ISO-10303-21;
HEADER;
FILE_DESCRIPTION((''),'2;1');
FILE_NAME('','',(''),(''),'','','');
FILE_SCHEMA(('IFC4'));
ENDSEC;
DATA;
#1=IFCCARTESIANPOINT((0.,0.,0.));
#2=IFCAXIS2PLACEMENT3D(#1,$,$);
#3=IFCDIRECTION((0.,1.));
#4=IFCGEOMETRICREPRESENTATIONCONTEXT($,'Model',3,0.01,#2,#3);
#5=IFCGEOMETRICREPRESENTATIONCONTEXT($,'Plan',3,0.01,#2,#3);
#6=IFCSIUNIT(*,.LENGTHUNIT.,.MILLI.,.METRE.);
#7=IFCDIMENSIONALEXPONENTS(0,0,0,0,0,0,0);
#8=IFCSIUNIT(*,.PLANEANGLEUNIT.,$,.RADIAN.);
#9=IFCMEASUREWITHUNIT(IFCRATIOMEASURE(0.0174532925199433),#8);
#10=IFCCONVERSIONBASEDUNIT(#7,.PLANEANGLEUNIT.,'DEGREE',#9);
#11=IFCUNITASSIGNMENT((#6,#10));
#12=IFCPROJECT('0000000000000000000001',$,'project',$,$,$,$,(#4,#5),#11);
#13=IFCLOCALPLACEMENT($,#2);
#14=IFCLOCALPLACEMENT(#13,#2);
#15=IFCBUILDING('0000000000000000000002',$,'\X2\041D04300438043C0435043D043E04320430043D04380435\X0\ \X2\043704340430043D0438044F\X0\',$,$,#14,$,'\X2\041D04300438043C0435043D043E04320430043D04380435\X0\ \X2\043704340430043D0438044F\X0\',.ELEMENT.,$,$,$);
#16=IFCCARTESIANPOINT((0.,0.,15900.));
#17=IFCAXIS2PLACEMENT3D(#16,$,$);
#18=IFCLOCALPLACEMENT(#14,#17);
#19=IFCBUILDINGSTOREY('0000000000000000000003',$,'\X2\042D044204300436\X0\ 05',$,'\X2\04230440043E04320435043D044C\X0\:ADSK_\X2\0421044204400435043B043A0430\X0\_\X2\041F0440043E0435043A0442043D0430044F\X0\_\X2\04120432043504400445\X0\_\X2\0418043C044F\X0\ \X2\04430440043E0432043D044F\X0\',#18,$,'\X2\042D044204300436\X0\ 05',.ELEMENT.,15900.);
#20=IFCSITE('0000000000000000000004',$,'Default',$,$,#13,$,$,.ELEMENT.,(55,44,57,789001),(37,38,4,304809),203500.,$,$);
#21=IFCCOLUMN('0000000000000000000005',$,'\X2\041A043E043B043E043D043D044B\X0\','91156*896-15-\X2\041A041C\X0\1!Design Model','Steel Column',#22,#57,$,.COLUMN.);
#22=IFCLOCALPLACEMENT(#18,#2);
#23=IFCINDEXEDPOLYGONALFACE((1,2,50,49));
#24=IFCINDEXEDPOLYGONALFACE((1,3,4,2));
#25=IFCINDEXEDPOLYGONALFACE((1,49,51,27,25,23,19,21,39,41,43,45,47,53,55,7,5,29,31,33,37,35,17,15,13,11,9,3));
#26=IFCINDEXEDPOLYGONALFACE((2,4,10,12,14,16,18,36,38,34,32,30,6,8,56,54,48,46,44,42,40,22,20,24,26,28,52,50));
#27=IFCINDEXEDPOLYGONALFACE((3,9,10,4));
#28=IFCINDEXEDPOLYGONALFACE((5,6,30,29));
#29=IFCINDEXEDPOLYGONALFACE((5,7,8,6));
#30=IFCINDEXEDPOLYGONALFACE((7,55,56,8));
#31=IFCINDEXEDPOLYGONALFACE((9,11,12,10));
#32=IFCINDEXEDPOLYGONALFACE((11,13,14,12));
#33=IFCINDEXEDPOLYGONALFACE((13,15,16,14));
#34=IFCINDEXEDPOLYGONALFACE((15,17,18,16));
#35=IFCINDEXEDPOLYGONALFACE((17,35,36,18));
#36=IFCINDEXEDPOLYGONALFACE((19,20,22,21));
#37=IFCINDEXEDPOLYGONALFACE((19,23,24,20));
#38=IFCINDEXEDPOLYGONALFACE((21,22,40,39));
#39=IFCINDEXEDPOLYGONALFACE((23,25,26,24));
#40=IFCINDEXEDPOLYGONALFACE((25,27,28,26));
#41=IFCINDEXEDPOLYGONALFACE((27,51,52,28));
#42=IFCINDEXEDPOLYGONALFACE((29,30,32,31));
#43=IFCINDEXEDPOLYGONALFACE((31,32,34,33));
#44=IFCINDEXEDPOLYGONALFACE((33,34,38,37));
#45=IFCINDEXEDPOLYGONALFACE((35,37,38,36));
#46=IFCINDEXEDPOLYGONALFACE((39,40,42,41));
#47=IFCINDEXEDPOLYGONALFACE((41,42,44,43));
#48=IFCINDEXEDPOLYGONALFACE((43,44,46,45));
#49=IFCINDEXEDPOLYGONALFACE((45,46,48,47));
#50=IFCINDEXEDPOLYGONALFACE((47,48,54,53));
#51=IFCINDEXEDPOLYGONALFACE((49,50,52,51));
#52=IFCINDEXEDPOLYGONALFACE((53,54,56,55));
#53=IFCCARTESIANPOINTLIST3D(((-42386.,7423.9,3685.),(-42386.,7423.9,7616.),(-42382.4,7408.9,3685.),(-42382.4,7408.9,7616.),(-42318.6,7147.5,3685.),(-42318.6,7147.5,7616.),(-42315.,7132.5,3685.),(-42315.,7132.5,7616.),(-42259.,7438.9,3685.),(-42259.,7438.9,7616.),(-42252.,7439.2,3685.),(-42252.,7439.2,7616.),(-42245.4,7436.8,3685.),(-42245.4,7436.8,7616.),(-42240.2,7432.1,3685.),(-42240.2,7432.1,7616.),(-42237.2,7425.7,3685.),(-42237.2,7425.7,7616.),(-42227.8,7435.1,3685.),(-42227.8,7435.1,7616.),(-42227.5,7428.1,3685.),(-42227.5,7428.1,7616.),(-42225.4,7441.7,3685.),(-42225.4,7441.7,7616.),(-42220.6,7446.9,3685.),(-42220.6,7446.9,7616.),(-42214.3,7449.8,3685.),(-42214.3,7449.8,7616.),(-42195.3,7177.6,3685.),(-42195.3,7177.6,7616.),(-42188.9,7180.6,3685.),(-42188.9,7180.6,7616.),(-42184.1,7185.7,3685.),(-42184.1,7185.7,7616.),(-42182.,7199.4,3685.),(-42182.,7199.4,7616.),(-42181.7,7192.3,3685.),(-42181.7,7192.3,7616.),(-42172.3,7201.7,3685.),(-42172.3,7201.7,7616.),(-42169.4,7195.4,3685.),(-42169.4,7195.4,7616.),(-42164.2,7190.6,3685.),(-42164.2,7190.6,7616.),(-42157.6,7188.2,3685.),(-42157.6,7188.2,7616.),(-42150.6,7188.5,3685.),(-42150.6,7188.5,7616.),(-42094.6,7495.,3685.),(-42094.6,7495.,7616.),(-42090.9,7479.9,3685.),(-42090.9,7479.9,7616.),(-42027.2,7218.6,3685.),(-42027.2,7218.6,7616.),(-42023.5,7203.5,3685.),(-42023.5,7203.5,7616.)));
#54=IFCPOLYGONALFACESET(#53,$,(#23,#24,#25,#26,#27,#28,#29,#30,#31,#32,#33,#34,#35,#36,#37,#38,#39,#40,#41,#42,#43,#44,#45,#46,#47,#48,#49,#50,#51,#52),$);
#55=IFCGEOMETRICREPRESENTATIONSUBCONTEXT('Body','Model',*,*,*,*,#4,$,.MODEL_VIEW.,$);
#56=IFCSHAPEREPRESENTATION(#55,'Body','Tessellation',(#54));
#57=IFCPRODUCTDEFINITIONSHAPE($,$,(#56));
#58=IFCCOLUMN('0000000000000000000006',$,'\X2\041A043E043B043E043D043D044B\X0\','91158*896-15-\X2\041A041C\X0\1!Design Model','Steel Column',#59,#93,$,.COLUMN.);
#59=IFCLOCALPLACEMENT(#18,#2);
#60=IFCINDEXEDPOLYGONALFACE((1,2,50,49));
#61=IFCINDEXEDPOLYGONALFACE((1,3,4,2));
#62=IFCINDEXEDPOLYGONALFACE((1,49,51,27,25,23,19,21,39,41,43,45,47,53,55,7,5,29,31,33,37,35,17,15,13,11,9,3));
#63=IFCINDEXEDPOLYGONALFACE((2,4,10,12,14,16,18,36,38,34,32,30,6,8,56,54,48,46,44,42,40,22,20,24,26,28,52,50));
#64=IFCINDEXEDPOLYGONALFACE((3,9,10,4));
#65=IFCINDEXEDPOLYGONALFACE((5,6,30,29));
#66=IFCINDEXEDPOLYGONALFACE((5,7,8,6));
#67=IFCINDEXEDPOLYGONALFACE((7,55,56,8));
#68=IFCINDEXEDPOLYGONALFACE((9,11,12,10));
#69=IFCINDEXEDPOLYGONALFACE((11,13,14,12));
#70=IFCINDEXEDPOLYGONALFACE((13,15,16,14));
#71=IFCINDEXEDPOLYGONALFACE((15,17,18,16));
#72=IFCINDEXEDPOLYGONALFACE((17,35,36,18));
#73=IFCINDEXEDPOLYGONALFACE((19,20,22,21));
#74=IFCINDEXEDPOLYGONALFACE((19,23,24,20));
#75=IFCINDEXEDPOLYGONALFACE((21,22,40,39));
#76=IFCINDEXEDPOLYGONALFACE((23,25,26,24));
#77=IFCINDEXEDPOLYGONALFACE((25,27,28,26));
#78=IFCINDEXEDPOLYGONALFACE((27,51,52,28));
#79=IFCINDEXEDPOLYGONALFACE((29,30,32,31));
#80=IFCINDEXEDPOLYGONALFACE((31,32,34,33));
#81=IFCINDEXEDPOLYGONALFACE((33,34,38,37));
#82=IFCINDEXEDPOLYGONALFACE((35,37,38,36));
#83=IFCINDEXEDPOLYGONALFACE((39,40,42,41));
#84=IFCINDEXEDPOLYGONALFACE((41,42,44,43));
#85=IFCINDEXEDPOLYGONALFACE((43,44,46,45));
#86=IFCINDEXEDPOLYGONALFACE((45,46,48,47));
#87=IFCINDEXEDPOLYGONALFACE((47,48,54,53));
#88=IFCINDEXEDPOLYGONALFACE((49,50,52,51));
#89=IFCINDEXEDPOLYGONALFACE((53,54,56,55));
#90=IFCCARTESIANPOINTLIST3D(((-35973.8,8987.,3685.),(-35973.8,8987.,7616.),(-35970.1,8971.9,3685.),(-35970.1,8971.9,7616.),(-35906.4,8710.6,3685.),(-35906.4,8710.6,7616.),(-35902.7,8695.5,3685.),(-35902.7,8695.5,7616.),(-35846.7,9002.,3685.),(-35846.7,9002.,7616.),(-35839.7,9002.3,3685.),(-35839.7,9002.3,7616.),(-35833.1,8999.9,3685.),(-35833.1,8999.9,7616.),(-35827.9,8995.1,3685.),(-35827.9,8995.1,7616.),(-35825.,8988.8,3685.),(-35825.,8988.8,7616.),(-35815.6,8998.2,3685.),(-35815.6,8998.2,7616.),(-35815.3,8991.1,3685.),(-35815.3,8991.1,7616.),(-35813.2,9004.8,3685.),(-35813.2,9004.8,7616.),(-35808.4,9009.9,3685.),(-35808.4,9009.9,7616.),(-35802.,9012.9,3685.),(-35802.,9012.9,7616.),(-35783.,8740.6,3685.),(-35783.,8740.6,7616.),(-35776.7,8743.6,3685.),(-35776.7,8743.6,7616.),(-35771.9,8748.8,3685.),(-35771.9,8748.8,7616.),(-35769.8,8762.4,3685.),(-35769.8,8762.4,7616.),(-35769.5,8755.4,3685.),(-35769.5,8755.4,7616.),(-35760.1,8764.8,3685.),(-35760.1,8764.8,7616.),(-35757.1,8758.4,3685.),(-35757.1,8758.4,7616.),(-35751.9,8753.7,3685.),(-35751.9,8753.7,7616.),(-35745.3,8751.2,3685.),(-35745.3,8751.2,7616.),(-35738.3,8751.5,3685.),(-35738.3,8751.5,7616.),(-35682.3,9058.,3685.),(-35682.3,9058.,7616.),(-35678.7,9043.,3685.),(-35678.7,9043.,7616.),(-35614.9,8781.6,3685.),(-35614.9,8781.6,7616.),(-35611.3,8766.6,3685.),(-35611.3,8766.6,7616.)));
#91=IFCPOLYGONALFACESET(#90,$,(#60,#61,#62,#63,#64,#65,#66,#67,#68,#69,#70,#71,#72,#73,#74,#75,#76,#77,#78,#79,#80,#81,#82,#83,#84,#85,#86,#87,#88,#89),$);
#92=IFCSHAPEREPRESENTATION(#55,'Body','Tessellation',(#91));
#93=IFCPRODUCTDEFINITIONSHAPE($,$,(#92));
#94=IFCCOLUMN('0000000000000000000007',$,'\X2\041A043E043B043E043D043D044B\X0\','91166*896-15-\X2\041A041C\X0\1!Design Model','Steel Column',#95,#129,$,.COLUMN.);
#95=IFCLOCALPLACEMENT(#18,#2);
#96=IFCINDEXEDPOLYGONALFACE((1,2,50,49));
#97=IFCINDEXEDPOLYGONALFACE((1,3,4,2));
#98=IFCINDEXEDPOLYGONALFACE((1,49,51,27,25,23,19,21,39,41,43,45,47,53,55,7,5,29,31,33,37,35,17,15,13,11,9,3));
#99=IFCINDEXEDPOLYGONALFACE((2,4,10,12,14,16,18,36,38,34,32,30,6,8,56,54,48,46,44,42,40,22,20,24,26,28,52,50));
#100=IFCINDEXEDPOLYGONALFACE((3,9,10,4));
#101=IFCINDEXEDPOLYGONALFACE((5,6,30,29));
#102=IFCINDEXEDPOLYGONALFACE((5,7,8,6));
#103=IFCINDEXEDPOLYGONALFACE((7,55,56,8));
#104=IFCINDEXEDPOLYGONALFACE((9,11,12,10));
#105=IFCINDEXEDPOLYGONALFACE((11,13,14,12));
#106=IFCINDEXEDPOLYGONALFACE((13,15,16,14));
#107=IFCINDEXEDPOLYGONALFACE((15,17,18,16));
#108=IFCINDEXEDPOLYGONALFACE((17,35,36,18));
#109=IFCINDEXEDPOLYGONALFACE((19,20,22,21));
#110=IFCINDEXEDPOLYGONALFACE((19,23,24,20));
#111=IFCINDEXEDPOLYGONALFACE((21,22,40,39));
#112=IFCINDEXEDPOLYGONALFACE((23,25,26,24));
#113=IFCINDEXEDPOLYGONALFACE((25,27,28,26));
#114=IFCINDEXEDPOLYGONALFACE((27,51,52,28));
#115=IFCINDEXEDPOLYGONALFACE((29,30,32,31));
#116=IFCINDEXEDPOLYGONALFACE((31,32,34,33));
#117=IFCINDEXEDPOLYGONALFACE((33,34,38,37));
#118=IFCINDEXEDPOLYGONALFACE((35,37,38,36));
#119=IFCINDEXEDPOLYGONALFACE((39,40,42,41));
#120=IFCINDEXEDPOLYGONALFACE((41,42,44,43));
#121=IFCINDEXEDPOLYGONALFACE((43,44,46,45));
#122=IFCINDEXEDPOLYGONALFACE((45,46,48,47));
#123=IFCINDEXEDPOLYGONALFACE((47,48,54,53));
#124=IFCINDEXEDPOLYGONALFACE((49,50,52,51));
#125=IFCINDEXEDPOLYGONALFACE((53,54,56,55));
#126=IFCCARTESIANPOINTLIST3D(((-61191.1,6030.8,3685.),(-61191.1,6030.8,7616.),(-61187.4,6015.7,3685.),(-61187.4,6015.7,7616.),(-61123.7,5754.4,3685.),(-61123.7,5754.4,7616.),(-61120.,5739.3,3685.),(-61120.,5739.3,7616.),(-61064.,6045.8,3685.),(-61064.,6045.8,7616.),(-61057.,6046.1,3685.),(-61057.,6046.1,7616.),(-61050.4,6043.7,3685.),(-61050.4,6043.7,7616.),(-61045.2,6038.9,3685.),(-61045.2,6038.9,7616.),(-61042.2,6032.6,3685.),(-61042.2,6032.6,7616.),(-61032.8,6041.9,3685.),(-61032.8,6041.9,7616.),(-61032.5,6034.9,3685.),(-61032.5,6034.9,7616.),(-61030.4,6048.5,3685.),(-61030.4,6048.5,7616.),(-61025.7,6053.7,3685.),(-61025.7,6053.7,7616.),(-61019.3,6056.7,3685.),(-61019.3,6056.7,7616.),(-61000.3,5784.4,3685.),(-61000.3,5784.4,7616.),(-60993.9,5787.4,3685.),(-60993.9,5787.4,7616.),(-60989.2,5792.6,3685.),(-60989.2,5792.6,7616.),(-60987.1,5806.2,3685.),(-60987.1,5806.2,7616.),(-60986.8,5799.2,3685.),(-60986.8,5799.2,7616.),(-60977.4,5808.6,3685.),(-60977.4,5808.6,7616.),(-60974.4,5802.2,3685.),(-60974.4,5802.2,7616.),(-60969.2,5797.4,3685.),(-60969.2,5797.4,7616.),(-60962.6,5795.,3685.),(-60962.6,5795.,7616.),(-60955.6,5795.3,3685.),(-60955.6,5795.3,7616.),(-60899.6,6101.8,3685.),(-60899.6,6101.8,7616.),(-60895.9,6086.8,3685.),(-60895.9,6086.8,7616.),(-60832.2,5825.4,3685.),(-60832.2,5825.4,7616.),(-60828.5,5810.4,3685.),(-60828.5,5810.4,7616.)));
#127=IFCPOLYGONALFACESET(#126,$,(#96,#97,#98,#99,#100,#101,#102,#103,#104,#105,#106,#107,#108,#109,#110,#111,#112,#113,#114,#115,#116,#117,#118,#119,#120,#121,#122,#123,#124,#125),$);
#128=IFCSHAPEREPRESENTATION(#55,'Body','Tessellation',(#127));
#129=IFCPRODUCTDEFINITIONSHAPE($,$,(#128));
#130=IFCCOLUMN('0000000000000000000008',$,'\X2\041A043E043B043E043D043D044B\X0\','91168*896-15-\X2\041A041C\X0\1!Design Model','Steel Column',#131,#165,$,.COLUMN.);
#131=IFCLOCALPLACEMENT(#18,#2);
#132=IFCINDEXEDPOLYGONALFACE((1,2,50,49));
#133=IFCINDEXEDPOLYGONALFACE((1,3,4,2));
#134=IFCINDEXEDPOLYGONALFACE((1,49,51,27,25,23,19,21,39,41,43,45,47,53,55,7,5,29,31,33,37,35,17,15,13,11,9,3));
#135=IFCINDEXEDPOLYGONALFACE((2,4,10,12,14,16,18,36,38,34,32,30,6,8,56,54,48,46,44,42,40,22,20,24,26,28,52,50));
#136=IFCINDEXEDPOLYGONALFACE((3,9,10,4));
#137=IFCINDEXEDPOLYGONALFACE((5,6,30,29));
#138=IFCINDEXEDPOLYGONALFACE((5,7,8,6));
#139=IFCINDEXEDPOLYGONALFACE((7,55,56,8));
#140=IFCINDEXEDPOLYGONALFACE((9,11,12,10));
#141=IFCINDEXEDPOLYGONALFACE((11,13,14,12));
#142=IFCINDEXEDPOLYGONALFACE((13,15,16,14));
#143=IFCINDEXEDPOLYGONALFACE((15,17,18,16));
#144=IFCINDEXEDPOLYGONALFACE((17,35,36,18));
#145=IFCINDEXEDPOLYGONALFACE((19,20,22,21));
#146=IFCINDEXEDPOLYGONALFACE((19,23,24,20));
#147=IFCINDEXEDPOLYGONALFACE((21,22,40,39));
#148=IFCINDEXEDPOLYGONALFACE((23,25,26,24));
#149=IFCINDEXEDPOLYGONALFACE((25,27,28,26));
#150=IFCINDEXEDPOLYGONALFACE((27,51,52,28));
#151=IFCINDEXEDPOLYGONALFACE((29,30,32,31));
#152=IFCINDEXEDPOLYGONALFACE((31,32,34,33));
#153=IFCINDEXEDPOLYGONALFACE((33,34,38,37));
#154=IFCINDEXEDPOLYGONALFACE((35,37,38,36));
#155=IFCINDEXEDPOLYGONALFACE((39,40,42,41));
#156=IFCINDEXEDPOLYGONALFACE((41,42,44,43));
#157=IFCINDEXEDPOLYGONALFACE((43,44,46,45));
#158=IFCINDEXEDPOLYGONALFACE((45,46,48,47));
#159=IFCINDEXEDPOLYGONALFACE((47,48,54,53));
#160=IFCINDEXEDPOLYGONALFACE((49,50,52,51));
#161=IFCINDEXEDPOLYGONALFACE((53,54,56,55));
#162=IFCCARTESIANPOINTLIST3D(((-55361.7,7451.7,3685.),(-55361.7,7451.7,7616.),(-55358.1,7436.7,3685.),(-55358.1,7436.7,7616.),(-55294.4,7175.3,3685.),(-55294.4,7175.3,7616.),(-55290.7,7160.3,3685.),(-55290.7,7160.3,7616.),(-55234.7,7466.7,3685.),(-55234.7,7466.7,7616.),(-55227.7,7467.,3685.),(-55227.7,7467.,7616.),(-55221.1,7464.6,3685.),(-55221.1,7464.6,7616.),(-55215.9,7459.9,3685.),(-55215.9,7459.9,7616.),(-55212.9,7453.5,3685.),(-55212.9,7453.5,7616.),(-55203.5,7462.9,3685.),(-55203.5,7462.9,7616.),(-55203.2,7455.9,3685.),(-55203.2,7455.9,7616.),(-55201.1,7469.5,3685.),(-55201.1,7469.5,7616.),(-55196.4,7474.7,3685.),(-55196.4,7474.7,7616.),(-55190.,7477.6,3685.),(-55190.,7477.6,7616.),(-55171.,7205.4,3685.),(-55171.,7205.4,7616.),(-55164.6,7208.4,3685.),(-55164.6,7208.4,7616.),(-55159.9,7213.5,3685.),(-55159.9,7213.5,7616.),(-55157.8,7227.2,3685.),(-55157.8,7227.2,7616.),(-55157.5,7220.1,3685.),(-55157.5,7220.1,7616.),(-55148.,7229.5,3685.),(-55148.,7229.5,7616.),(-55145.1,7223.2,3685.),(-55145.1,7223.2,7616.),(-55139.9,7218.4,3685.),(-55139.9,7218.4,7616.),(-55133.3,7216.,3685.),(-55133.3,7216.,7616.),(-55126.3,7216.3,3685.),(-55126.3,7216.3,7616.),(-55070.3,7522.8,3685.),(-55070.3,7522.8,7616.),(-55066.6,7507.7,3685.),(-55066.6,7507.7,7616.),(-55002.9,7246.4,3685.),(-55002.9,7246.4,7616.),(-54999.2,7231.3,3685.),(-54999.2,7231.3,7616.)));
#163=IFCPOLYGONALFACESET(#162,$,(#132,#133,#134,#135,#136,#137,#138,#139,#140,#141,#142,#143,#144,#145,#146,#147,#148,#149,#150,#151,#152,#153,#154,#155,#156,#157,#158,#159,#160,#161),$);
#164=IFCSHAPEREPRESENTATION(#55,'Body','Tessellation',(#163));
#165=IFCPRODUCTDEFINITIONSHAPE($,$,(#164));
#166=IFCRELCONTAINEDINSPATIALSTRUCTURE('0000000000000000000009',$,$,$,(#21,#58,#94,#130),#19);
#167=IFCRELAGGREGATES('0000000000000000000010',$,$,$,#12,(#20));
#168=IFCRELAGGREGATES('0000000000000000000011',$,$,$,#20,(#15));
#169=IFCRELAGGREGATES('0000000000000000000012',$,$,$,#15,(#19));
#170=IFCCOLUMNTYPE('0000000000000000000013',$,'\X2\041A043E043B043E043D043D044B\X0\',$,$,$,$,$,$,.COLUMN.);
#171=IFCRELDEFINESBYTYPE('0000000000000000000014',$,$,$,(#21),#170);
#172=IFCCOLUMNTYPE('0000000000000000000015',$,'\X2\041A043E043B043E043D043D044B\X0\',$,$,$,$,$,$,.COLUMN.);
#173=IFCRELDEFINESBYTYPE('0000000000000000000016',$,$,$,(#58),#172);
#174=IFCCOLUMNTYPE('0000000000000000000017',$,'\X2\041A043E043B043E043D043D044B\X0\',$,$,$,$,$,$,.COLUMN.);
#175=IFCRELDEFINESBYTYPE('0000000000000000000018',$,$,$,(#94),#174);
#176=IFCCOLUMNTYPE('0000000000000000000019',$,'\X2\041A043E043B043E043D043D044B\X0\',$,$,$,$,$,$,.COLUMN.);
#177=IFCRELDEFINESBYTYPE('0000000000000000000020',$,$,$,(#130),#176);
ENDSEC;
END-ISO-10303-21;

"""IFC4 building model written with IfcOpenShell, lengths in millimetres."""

from ifc_helpers import new_model, entity, si_unit, converted_unit, direction, frame, origin, place, context, subcontext, project, spatial, indexed_curve, outline, extrude, type_object, element, save


model = new_model("IFC4")

# Units and contexts
model_context = context("Model", 3, precision=0.01, world=origin(), true_north=direction((0.0, 1.0)))
plan_context = context("Plan", 3, precision=0.01, world=origin(), true_north=direction((0.0, 1.0)))
body_context = subcontext(model_context, "Body", "Model", "MODEL_VIEW")
ifc_project = project(units=[si_unit("LENGTHUNIT", "METRE", prefix="MILLI"), converted_unit("PLANEANGLEUNIT", "DEGREE", entity("IfcRatioMeasure", 0.0174532925199433), si_unit("PLANEANGLEUNIT", "RADIAN"), dimensions=[0, 0, 0, 0, 0, 0, 0])], contexts=[model_context, plan_context])

# Site, building, storey
site_placement = place(None, origin())
site = spatial("IfcSite", under=ifc_project, at=site_placement, Name="Default", CompositionType="ELEMENT", RefLatitude=(55, 44, 57, 789001), RefLongitude=(37, 38, 4, 304809), RefElevation=203500.0)
building_placement = place(site_placement, origin())
building = spatial("IfcBuilding", under=site, at=building_placement, Name="Наименование здания", LongName="Наименование здания", CompositionType="ELEMENT")
storey_placement = place(building_placement, frame((0.0, 0.0, 15900.0)))
storey = spatial("IfcBuildingStorey", under=building, at=storey_placement, Name="Этаж 05", ObjectType="Уровень:ADSK_Стрелка_Проектная_Вверх_Имя уровня", LongName="Этаж 05", CompositionType="ELEMENT", Elevation=15900.0)

# Columns
placement = place(storey_placement, origin())
column_type_1 = type_object("IfcColumnType", Name="Колонны", PredefinedType="COLUMN")
element("IfcColumn", 1, at=placement, inside=storey, type_object=column_type_1, Name="Колонны", Description="91156*896-15-КМ1!Design Model", ObjectType="Steel Column", PredefinedType="COLUMN", context=body_context, shape_type="SweptSolid", body=[
    extrude(outline(indexed_curve([(-150.0, -150.0), (-134.5, -150.0), (-134.5, -23.0), (-133.1, -16.1), (-129.2, -10.3), (-123.4, -6.4), (-116.5, -5.0), (116.5, -5.0), (123.4, -6.4), (129.2, -10.3), (133.1, -16.1), (134.5, -23.0), (134.5, -150.0), (150.0, -150.0), (150.0, 150.0), (134.5, 150.0), (134.5, 23.0), (133.1, 16.1), (129.2, 10.3), (123.4, 6.4), (116.5, 5.0), (-116.5, 5.0), (-123.4, 6.4), (-129.2, 10.3), (-133.1, 16.1), (-134.5, 23.0), (-134.5, 150.0), (-150.0, 150.0), (-150.0, -150.0)], self_intersect=False)), frame((-42204.8, 7313.7, 3685.0), z_axis=(0.0, 0.0, 1.0), x_axis=(-0.236826, 0.971552, 0.0)), (0.0, 0.0, 1.0), 3931.0),
])
column_type_2 = type_object("IfcColumnType", Name="Колонны", PredefinedType="COLUMN")
element("IfcColumn", 2, at=placement, inside=storey, type_object=column_type_2, Name="Колонны", Description="91158*896-15-КМ1!Design Model", ObjectType="Steel Column", PredefinedType="COLUMN", context=body_context, shape_type="SweptSolid", body=[
    extrude(outline(indexed_curve([(-150.0, -150.0), (-134.5, -150.0), (-134.5, -23.0), (-133.1, -16.1), (-129.2, -10.3), (-123.4, -6.4), (-116.5, -5.0), (116.5, -5.0), (123.4, -6.4), (129.2, -10.3), (133.1, -16.1), (134.5, -23.0), (134.5, -150.0), (150.0, -150.0), (150.0, 150.0), (134.5, 150.0), (134.5, 23.0), (133.1, 16.1), (129.2, 10.3), (123.4, 6.4), (116.5, 5.0), (-116.5, 5.0), (-123.4, 6.4), (-129.2, 10.3), (-133.1, 16.1), (-134.5, 23.0), (-134.5, 150.0), (-150.0, 150.0), (-150.0, -150.0)], self_intersect=False)), frame((-35792.5, 8876.8, 3685.0), z_axis=(0.0, 0.0, 1.0), x_axis=(-0.236826, 0.971552, 0.0)), (0.0, 0.0, 1.0), 3931.0),
])
column_type_3 = type_object("IfcColumnType", Name="Колонны", PredefinedType="COLUMN")
element("IfcColumn", 3, at=placement, inside=storey, type_object=column_type_3, Name="Колонны", Description="91166*896-15-КМ1!Design Model", ObjectType="Steel Column", PredefinedType="COLUMN", context=body_context, shape_type="SweptSolid", body=[
    extrude(outline(indexed_curve([(-150.0, -150.0), (-134.5, -150.0), (-134.5, -23.0), (-133.1, -16.1), (-129.2, -10.3), (-123.4, -6.4), (-116.5, -5.0), (116.5, -5.0), (123.4, -6.4), (129.2, -10.3), (133.1, -16.1), (134.5, -23.0), (134.5, -150.0), (150.0, -150.0), (150.0, 150.0), (134.5, 150.0), (134.5, 23.0), (133.1, 16.1), (129.2, 10.3), (123.4, 6.4), (116.5, 5.0), (-116.5, 5.0), (-123.4, 6.4), (-129.2, 10.3), (-133.1, 16.1), (-134.5, 23.0), (-134.5, 150.0), (-150.0, 150.0), (-150.0, -150.0)], self_intersect=False)), frame((-61009.8, 5920.6, 3685.0), z_axis=(0.0, 0.0, 1.0), x_axis=(-0.236826, 0.971552, 0.0)), (0.0, 0.0, 1.0), 3931.0),
])
column_type_4 = type_object("IfcColumnType", Name="Колонны", PredefinedType="COLUMN")
element("IfcColumn", 4, at=placement, inside=storey, type_object=column_type_4, Name="Колонны", Description="91168*896-15-КМ1!Design Model", ObjectType="Steel Column", PredefinedType="COLUMN", context=body_context, shape_type="SweptSolid", body=[
    extrude(outline(indexed_curve([(-150.0, -150.0), (-134.5, -150.0), (-134.5, -23.0), (-133.1, -16.1), (-129.2, -10.3), (-123.4, -6.4), (-116.5, -5.0), (116.5, -5.0), (123.4, -6.4), (129.2, -10.3), (133.1, -16.1), (134.5, -23.0), (134.5, -150.0), (150.0, -150.0), (150.0, 150.0), (134.5, 150.0), (134.5, 23.0), (133.1, 16.1), (129.2, 10.3), (123.4, 6.4), (116.5, 5.0), (-116.5, 5.0), (-123.4, 6.4), (-129.2, 10.3), (-133.1, 16.1), (-134.5, 23.0), (-134.5, 150.0), (-150.0, 150.0), (-150.0, -150.0)], self_intersect=False)), frame((-55180.5, 7341.5, 3685.0), z_axis=(0.0, 0.0, 1.0), x_axis=(-0.236826, 0.971552, 0.0)), (0.0, 0.0, 1.0), 3931.0),
])

save(model, "model.ifc")
